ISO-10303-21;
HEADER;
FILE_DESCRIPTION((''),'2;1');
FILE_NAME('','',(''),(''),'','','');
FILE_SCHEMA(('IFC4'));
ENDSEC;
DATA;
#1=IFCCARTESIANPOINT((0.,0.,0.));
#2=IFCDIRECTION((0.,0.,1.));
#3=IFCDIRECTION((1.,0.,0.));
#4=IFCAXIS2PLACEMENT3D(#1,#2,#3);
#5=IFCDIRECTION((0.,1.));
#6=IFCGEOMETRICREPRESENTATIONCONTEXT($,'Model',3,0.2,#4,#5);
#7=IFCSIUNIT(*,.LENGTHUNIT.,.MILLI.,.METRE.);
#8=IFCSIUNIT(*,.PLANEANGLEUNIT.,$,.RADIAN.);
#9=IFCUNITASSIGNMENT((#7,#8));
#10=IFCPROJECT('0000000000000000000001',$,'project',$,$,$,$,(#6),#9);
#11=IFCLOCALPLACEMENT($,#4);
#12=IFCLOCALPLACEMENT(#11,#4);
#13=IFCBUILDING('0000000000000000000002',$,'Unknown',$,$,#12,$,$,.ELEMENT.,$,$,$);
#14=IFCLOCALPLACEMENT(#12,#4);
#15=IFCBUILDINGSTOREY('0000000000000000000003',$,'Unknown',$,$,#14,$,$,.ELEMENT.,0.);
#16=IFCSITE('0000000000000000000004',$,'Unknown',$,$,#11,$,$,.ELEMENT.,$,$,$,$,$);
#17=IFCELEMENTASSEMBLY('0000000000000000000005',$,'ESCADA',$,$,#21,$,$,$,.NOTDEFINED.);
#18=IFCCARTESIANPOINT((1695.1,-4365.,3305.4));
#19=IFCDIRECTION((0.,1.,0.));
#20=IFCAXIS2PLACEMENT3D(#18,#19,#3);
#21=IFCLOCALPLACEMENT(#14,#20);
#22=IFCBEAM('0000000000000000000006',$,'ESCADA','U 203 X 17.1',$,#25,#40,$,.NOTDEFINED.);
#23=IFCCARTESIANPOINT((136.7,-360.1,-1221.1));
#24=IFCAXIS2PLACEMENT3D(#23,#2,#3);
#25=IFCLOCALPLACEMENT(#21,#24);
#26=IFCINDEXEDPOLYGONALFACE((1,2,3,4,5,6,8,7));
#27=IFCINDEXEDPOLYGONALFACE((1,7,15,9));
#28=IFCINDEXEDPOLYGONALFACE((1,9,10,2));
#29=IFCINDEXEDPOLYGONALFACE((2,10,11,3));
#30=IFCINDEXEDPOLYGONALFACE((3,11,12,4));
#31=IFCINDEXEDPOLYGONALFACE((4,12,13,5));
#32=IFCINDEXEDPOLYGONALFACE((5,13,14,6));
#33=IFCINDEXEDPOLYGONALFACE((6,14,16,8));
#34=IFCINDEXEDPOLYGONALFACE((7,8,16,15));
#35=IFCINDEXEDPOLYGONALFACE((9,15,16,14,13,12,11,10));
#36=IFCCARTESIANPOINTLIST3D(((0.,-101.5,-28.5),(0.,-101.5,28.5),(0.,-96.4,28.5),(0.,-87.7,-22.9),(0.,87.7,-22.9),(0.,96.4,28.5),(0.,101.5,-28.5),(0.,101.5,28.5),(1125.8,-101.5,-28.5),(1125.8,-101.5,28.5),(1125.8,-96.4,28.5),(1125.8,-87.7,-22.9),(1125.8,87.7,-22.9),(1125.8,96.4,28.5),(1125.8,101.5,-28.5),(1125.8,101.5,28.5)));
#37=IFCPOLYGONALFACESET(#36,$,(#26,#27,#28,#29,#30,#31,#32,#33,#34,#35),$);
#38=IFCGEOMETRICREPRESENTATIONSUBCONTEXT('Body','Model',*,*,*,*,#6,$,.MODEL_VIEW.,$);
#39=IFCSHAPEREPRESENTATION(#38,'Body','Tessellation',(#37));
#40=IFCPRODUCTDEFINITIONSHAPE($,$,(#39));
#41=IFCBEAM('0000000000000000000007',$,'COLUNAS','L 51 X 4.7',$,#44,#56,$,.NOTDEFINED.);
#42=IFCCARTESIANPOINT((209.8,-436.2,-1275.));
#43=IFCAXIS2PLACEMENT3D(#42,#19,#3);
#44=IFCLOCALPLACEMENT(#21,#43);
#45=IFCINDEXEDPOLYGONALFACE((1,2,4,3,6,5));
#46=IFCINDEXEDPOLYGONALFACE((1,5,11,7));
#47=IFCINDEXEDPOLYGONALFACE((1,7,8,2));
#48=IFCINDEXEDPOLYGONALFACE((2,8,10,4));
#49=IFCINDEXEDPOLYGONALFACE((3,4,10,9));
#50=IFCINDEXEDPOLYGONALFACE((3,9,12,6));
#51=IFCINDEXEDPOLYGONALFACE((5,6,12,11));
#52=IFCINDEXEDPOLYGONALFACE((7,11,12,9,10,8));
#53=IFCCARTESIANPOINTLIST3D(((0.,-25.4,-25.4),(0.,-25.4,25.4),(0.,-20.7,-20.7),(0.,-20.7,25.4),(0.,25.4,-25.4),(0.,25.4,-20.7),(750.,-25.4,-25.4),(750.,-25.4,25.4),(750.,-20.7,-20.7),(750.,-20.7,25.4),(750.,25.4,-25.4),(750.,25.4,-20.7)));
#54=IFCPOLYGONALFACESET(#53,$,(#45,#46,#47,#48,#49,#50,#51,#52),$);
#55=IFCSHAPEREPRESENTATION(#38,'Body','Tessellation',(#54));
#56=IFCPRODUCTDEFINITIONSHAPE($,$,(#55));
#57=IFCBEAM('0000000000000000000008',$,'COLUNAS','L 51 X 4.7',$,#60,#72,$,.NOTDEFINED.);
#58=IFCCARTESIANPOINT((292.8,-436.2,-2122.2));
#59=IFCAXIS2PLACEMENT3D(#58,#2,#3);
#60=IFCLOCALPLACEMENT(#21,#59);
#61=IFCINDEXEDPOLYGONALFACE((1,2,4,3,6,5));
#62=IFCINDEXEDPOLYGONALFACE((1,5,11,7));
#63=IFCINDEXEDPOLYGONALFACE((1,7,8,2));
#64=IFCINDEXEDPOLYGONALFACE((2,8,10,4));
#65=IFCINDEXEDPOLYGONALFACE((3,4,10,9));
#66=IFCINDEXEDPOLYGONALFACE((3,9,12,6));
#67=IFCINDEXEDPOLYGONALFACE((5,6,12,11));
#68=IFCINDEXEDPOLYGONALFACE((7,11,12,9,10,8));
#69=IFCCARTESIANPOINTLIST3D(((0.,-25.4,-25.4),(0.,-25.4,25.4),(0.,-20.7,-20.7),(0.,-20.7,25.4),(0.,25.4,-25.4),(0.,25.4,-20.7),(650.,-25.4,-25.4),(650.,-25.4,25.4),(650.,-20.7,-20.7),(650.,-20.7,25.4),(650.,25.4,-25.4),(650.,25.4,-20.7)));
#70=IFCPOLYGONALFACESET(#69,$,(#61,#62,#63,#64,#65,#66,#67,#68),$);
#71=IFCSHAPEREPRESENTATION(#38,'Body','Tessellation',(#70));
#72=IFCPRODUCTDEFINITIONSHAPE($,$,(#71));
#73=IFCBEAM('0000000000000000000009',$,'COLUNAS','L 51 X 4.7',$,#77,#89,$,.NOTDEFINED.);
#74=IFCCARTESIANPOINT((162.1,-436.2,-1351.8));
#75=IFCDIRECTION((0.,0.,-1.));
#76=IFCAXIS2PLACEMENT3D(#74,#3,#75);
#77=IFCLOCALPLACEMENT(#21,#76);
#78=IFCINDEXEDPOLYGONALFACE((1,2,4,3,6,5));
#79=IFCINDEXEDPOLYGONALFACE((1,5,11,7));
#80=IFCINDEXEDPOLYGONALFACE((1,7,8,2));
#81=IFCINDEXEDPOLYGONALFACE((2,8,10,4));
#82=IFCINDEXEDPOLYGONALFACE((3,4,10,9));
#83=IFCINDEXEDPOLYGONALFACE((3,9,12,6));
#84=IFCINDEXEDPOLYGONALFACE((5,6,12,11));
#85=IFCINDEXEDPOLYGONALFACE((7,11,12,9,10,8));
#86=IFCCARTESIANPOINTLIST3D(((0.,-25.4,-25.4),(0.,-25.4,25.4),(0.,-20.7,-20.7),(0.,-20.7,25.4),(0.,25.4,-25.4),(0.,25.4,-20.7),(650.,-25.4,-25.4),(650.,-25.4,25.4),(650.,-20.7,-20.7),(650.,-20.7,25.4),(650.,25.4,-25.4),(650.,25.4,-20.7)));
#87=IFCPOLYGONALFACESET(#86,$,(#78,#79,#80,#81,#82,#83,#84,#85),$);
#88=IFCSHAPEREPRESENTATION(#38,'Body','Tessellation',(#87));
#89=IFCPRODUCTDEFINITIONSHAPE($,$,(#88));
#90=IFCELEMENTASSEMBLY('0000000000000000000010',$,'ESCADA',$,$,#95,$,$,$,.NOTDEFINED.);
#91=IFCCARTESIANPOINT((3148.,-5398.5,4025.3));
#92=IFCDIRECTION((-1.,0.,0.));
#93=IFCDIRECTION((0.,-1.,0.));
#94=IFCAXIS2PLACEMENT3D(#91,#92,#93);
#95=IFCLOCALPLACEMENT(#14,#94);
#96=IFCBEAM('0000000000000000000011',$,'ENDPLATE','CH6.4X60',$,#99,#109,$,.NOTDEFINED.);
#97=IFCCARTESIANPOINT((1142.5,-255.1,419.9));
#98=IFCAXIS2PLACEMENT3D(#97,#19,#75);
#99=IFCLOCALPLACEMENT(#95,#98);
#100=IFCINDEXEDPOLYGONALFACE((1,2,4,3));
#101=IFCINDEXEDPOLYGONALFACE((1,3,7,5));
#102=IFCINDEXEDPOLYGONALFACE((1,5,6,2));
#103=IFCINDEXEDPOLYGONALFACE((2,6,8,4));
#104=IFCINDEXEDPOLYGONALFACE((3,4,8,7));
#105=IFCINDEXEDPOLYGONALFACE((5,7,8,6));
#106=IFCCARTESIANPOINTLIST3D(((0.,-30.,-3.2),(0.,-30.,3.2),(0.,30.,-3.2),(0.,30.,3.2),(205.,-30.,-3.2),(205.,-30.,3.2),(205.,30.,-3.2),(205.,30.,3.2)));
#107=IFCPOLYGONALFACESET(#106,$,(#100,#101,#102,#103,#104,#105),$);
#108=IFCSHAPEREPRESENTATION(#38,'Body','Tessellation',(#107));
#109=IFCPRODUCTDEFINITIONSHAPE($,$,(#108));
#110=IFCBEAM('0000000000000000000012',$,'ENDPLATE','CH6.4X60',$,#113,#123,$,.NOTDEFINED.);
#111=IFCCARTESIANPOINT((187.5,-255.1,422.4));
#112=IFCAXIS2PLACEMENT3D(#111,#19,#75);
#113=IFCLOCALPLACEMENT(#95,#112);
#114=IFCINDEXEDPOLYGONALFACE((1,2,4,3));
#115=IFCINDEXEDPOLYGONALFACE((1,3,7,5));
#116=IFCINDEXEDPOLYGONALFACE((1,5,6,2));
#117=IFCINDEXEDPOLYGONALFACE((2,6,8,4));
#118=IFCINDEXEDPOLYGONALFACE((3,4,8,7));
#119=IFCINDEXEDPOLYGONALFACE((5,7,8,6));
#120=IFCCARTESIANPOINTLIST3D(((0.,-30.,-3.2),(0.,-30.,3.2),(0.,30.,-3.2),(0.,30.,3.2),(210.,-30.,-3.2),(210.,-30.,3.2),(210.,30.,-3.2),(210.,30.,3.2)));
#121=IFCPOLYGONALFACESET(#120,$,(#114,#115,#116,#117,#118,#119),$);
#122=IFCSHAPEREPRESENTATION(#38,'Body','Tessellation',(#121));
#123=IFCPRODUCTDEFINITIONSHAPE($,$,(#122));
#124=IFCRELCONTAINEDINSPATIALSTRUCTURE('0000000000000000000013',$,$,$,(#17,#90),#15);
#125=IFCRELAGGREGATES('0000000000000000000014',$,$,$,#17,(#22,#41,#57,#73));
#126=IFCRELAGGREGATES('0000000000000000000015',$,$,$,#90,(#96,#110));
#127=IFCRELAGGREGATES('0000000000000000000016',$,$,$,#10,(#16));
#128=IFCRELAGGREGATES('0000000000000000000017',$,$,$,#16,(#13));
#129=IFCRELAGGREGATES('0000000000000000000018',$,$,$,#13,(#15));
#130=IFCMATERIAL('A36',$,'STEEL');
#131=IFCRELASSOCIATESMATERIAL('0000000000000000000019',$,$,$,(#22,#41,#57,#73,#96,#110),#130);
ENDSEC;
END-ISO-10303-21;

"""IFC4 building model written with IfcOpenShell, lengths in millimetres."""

from ifc_helpers import new_model, si_unit, direction, frame, origin_with_axes, place, context, subcontext, project, spatial, line, indexed_curve, outline, extrude, material, element, aggregate, save


model = new_model("IFC4")

# Units and contexts
model_context = context("Model", 3, precision=0.2, world=origin_with_axes(), true_north=direction((0.0, 1.0)))
body_context = subcontext(model_context, "Body", "Model", "MODEL_VIEW")
ifc_project = project(units=[si_unit("LENGTHUNIT", "METRE", prefix="MILLI"), si_unit("PLANEANGLEUNIT", "RADIAN")], contexts=[model_context])

# Site, building, storey
site_placement = place(None, origin_with_axes())
site = spatial("IfcSite", under=ifc_project, at=site_placement, Name="Unknown", CompositionType="ELEMENT")
building_placement = place(site_placement, origin_with_axes())
building = spatial("IfcBuilding", under=site, at=building_placement, Name="Unknown", CompositionType="ELEMENT")
storey_placement = place(building_placement, origin_with_axes())
storey = spatial("IfcBuildingStorey", under=building, at=storey_placement, Name="Unknown", CompositionType="ELEMENT", Elevation=0.0)

# Element assemblies, beams
assembly_1_placement = place(storey_placement, frame((1695.1, -4365.0, 3305.4), z_axis=(0.0, 1.0, 0.0), x_axis=(1.0, 0.0, 0.0)))
assembly_1 = element("IfcElementAssembly", 1, at=assembly_1_placement, inside=storey, Name="ESCADA", PredefinedType="NOTDEFINED")
ifc_material_1 = material(Name="A36", Category="STEEL")
beam_1_placement = place(assembly_1_placement, frame((136.7, -360.1, -1221.1), z_axis=(0.0, 0.0, 1.0), x_axis=(1.0, 0.0, 0.0)))
beam_1 = element("IfcBeam", 2, at=beam_1_placement, material=ifc_material_1, Name="ESCADA", Description="U 203 X 17.1", PredefinedType="NOTDEFINED", context=body_context, shape_type="SolidModel", body=[
    extrude(outline(indexed_curve([(-28.5, -101.5), (28.5, -101.5), (28.5, -96.4), (-22.9, -87.7), (-22.9, 87.7), (28.5, 96.4), (28.5, 101.5), (-28.5, 101.5)], segments=[line(1, 2, 3, 4, 5, 6, 7, 8, 1)])), frame((0.0, 0.0, 0.0), z_axis=(-1.0, 0.0, 0.0), x_axis=(0.0, 0.0, 1.0)), (0.0, 0.0, -1.0), 1125.8),
])
beam_2_placement = place(assembly_1_placement, frame((209.8, -436.2, -1275.0), z_axis=(0.0, 1.0, 0.0), x_axis=(1.0, 0.0, 0.0)))
beam_2 = element("IfcBeam", 3, at=beam_2_placement, material=ifc_material_1, Name="COLUNAS", Description="L 51 X 4.7", PredefinedType="NOTDEFINED", context=body_context, shape_type="SolidModel", body=[
    extrude(outline(indexed_curve([(-25.4, -25.4), (25.4, -25.4), (25.4, -20.7), (-20.7, -20.7), (-20.7, 25.4), (-25.4, 25.4)], segments=[line(1, 2, 3, 4, 5, 6, 1)])), frame((0.0, 0.0, 0.0), z_axis=(-1.0, 0.0, 0.0), x_axis=(0.0, 0.0, 1.0)), (0.0, 0.0, -1.0), 750.0),
])
beam_3_placement = place(assembly_1_placement, frame((292.8, -436.2, -2122.2), z_axis=(0.0, 0.0, 1.0), x_axis=(1.0, 0.0, 0.0)))
beam_3 = element("IfcBeam", 4, at=beam_3_placement, material=ifc_material_1, Name="COLUNAS", Description="L 51 X 4.7", PredefinedType="NOTDEFINED", context=body_context, shape_type="SolidModel", body=[
    extrude(outline(indexed_curve([(-25.4, -25.4), (25.4, -25.4), (25.4, -20.7), (-20.7, -20.7), (-20.7, 25.4), (-25.4, 25.4)], segments=[line(1, 2, 3, 4, 5, 6, 1)])), frame((0.0, 0.0, 0.0), z_axis=(-1.0, 0.0, 0.0), x_axis=(0.0, 0.0, 1.0)), (0.0, 0.0, -1.0), 650.0),
])
beam_4_placement = place(assembly_1_placement, frame((162.1, -436.2, -1351.8), z_axis=(1.0, 0.0, 0.0), x_axis=(0.0, 0.0, -1.0)))
beam_4 = element("IfcBeam", 5, at=beam_4_placement, material=ifc_material_1, Name="COLUNAS", Description="L 51 X 4.7", PredefinedType="NOTDEFINED", context=body_context, shape_type="SolidModel", body=[
    extrude(outline(indexed_curve([(-25.4, -25.4), (25.4, -25.4), (25.4, -20.7), (-20.7, -20.7), (-20.7, 25.4), (-25.4, 25.4)], segments=[line(1, 2, 3, 4, 5, 6, 1)])), frame((0.0, 0.0, 0.0), z_axis=(-1.0, 0.0, 0.0), x_axis=(0.0, 0.0, 1.0)), (0.0, 0.0, -1.0), 650.0),
])
aggregate(assembly_1, [beam_1, beam_2, beam_3, beam_4])
assembly_2_placement = place(storey_placement, frame((3148.0, -5398.5, 4025.3), z_axis=(-1.0, 0.0, 0.0), x_axis=(0.0, -1.0, 0.0)))
assembly_2 = element("IfcElementAssembly", 6, at=assembly_2_placement, inside=storey, Name="ESCADA", PredefinedType="NOTDEFINED")
beam_5_placement = place(assembly_2_placement, frame((1142.5, -255.1, 419.9), z_axis=(0.0, 1.0, 0.0), x_axis=(0.0, 0.0, -1.0)))
beam_5 = element("IfcBeam", 7, at=beam_5_placement, material=ifc_material_1, Name="ENDPLATE", Description="CH6.4X60", PredefinedType="NOTDEFINED", context=body_context, shape_type="SolidModel", body=[
    extrude(outline(indexed_curve([(-3.2, -30.0), (3.2, -30.0), (3.2, 30.0), (-3.2, 30.0)], segments=[line(1, 2, 3, 4, 1)])), frame((0.0, 0.0, 0.0), z_axis=(-1.0, 0.0, 0.0), x_axis=(0.0, 0.0, 1.0)), (0.0, 0.0, -1.0), 205.0),
])
beam_6_placement = place(assembly_2_placement, frame((187.5, -255.1, 422.4), z_axis=(0.0, 1.0, 0.0), x_axis=(0.0, 0.0, -1.0)))
beam_6 = element("IfcBeam", 8, at=beam_6_placement, material=ifc_material_1, Name="ENDPLATE", Description="CH6.4X60", PredefinedType="NOTDEFINED", context=body_context, shape_type="SolidModel", body=[
    extrude(outline(indexed_curve([(-3.2, -30.0), (3.2, -30.0), (3.2, 30.0), (-3.2, 30.0)], segments=[line(1, 2, 3, 4, 1)])), frame((0.0, 0.0, 0.0), z_axis=(-1.0, 0.0, 0.0), x_axis=(0.0, 0.0, 1.0)), (0.0, 0.0, -1.0), 210.0),
])
aggregate(assembly_2, [beam_5, beam_6])

save(model, "model.ifc")
